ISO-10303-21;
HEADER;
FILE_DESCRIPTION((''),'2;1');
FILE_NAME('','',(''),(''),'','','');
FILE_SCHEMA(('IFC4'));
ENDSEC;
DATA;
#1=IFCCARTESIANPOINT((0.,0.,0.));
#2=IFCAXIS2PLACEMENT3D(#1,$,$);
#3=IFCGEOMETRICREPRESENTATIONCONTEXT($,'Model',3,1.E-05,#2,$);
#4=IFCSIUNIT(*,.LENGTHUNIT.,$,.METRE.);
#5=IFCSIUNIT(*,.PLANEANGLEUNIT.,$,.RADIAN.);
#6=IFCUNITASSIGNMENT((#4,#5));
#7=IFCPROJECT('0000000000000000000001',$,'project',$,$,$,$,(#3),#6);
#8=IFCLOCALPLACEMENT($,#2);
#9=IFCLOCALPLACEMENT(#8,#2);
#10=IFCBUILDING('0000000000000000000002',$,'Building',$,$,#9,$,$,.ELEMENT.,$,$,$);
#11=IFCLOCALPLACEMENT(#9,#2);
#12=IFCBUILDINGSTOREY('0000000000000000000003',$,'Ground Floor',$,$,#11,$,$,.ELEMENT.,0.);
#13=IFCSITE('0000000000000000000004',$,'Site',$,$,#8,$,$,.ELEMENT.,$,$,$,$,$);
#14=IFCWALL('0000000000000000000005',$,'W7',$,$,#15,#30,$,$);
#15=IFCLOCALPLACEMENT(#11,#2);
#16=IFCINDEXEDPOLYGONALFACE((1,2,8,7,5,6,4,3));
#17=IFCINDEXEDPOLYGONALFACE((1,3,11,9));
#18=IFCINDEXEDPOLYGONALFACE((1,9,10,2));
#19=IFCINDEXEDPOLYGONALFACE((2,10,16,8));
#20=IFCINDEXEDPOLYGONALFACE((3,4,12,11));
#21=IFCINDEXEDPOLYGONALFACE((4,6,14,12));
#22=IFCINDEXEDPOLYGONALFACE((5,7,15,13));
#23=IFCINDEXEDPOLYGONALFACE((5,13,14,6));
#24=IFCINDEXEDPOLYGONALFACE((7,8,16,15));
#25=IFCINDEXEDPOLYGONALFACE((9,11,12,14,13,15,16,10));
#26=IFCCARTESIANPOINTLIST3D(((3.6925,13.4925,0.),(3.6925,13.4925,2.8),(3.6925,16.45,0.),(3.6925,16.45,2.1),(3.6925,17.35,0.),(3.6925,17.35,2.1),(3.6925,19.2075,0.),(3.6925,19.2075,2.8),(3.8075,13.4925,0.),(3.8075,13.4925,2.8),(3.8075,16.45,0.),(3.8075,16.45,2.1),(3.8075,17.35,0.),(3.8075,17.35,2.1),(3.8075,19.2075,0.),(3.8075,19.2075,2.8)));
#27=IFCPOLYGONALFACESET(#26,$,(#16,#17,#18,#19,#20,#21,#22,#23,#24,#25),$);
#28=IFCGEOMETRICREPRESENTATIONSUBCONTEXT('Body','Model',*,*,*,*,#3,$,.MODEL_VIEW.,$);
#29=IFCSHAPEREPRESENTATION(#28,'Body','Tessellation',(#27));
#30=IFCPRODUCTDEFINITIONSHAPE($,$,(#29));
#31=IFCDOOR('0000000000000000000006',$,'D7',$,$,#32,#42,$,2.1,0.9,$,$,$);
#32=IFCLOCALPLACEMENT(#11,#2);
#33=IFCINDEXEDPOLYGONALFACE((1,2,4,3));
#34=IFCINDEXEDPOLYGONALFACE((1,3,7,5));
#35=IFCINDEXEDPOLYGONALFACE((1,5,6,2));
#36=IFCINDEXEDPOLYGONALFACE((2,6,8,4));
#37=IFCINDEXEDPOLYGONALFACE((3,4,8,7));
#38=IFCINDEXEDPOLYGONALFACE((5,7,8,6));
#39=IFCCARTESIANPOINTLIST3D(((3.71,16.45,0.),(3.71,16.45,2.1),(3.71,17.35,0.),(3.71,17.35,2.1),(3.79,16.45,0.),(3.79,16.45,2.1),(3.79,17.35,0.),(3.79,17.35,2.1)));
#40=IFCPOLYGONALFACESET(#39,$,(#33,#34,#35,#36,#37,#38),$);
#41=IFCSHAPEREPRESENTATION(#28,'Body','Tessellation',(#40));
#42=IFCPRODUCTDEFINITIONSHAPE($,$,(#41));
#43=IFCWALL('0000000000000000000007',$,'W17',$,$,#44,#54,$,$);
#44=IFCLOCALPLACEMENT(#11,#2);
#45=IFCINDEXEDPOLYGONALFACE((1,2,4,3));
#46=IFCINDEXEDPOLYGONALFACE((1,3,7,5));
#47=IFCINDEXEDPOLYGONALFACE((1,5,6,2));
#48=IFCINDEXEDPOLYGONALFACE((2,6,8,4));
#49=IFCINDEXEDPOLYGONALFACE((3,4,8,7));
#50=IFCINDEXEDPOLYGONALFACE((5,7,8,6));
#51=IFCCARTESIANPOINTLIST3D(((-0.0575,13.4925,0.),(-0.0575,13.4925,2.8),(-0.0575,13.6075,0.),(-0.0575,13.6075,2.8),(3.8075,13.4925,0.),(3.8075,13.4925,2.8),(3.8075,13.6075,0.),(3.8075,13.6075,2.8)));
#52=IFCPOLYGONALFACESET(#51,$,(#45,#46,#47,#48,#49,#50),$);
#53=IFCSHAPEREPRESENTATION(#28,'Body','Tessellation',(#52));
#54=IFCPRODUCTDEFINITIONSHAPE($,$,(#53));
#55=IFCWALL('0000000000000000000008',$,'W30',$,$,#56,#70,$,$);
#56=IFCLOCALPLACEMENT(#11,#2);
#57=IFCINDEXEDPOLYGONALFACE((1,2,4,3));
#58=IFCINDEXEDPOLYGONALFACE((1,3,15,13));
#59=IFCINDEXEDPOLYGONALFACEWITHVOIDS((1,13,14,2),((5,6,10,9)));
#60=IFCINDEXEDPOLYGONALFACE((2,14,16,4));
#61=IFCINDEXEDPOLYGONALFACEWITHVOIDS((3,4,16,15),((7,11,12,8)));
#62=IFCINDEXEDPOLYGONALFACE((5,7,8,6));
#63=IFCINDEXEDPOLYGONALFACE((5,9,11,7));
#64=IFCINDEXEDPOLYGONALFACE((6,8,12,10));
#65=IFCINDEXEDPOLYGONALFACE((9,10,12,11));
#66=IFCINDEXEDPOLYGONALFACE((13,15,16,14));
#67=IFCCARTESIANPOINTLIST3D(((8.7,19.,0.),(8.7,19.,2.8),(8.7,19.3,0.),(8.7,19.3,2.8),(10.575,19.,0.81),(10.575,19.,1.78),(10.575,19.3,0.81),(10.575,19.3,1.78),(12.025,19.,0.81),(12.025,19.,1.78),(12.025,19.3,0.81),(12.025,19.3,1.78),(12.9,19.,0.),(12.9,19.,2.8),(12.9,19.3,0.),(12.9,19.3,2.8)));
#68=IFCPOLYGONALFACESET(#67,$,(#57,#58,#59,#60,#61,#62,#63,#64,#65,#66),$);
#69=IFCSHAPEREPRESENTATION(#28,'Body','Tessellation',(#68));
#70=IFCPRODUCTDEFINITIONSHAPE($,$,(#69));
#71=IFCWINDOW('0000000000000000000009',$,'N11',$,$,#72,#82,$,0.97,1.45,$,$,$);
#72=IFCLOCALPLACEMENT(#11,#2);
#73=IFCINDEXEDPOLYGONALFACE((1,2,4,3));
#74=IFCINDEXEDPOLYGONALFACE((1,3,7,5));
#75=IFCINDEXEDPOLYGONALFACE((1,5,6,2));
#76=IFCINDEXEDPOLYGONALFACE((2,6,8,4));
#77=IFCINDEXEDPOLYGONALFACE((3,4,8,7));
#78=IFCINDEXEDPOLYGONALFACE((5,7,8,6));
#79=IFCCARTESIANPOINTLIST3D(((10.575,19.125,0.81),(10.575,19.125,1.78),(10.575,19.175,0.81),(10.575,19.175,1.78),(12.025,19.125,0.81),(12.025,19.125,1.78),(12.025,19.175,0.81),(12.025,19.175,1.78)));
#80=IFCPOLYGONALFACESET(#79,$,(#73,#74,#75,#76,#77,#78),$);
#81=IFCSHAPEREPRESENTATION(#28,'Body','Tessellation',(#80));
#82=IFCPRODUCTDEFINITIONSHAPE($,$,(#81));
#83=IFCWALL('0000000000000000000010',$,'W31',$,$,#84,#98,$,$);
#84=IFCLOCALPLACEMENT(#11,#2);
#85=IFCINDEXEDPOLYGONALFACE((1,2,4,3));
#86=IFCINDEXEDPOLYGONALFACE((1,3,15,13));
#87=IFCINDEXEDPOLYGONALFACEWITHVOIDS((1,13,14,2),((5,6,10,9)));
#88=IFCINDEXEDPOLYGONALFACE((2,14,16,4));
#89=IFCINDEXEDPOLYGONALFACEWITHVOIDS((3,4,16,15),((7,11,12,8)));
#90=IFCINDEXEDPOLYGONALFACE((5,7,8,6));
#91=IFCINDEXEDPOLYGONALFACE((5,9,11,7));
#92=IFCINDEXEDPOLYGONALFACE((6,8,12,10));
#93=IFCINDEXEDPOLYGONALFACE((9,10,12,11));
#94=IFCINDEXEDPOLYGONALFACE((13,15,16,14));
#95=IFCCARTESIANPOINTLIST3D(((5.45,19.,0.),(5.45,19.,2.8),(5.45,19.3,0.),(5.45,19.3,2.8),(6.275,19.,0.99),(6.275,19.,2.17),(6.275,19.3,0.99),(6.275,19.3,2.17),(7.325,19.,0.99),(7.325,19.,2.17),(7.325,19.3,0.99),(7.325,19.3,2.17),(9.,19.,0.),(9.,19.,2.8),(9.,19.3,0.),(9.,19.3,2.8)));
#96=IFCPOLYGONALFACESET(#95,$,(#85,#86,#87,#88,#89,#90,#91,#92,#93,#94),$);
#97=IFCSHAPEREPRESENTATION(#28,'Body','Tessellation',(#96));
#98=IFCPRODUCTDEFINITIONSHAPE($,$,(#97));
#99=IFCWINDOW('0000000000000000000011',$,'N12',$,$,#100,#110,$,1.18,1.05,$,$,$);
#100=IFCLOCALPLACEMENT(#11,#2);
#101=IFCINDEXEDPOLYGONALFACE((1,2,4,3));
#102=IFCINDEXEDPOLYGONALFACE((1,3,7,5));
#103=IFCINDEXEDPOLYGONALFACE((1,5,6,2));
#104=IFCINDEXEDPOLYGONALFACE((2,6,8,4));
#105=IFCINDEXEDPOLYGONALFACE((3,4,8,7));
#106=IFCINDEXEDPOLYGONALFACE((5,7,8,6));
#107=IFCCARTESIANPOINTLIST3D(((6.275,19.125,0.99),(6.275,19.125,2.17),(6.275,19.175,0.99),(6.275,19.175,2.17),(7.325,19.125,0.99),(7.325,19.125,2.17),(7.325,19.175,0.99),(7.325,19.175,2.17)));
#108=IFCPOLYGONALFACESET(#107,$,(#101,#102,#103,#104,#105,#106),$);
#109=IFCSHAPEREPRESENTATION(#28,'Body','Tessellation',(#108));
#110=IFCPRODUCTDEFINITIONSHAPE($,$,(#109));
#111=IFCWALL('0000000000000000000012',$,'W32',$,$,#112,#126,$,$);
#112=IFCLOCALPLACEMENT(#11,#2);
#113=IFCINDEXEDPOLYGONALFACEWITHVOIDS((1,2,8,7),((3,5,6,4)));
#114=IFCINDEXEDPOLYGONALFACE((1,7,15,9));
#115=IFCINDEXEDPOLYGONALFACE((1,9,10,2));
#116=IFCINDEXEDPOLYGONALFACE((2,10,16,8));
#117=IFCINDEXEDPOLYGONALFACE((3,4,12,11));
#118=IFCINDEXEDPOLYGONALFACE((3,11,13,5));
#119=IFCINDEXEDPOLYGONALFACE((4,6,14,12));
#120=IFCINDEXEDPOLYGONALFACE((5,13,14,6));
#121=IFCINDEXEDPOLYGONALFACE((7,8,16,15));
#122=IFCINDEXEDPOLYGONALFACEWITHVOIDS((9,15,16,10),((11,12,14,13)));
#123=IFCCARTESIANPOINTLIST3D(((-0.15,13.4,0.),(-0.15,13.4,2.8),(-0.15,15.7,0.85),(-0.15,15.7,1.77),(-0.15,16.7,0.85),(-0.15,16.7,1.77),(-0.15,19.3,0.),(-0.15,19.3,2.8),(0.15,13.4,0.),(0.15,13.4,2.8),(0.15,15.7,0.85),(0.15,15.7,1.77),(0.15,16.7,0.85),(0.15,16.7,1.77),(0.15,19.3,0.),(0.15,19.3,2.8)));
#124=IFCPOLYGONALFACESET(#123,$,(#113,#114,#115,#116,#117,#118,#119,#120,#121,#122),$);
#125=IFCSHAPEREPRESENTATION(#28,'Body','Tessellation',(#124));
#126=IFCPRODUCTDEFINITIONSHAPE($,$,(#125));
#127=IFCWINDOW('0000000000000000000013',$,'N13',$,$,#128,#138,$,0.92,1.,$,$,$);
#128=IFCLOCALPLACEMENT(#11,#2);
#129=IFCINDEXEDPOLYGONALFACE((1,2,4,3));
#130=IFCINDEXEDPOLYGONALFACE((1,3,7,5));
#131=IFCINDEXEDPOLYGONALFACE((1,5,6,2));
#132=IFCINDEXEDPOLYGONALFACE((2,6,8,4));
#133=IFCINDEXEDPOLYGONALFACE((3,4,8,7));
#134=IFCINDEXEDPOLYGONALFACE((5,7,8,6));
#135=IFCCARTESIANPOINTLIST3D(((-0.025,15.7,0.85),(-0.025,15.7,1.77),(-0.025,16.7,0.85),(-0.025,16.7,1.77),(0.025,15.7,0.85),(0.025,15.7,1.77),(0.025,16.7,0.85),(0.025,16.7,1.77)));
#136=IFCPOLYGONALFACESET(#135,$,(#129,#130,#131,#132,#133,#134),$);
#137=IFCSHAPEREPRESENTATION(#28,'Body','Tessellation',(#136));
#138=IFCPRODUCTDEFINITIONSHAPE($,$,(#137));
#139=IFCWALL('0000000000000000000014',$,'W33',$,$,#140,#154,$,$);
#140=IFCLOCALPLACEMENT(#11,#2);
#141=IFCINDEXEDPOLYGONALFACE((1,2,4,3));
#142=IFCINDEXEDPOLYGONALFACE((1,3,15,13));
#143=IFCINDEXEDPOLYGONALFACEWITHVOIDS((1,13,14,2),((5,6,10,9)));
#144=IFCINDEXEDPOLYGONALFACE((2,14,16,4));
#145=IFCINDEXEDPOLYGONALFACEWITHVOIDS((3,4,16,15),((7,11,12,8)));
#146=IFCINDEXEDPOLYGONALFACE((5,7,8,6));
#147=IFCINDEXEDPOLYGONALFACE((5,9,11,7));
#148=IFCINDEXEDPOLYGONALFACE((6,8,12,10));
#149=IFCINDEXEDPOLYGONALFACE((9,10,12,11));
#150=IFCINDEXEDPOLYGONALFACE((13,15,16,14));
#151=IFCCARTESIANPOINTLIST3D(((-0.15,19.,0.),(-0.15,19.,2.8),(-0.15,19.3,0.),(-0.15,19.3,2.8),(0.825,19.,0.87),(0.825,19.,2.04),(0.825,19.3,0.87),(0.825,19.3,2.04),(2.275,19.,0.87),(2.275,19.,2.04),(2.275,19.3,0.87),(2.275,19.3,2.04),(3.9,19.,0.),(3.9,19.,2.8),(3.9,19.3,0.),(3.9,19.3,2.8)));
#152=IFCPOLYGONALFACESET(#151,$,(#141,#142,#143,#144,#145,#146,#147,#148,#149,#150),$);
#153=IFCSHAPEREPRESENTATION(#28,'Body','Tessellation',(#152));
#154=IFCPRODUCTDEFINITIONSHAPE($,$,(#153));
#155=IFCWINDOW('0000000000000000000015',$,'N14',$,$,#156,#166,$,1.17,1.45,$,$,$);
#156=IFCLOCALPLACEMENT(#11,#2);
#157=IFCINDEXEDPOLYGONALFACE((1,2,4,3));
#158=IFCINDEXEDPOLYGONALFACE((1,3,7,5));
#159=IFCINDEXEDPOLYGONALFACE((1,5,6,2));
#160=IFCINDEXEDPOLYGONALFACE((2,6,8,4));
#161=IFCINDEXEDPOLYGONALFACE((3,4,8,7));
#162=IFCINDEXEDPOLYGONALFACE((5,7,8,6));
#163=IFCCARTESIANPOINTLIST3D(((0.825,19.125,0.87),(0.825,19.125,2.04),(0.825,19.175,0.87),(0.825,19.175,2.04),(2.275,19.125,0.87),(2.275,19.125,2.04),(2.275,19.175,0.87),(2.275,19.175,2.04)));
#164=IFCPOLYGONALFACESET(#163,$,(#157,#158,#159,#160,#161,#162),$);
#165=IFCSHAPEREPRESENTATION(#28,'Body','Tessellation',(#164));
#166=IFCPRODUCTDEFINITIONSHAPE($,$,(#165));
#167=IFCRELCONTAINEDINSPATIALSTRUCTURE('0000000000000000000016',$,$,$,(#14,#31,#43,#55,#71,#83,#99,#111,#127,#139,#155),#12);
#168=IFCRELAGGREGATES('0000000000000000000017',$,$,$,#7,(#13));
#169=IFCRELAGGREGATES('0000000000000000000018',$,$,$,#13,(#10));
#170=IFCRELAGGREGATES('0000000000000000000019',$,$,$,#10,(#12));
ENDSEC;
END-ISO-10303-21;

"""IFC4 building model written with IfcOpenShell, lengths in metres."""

from ifc_helpers import new_model, si_unit, frame, frame_2d, origin, origin_2d, place, context, subcontext, project, spatial, rectangle, extrude, element, fill, save


model = new_model("IFC4")

# Units and contexts
model_context = context("Model", 3, precision=1e-05, world=origin())
body_context = subcontext(model_context, "Body", "Model", "MODEL_VIEW")
ifc_project = project(units=[si_unit("LENGTHUNIT", "METRE"), si_unit("PLANEANGLEUNIT", "RADIAN")], contexts=[model_context])

# Site, building, storey
site_placement = place(None, origin())
site = spatial("IfcSite", under=ifc_project, at=site_placement, Name="Site", CompositionType="ELEMENT")
building_placement = place(site_placement, origin())
building = spatial("IfcBuilding", under=site, at=building_placement, Name="Building", CompositionType="ELEMENT")
storey_placement = place(building_placement, origin())
storey = spatial("IfcBuildingStorey", under=building, at=storey_placement, Name="Ground Floor", CompositionType="ELEMENT", Elevation=0.0)

# Wall, opening, door
wall_1_placement = place(storey_placement, frame((3.75, 13.55, 0.0), x_axis=(0.0, 1.0, 0.0)))
wall_1 = element("IfcWall", 1, at=wall_1_placement, inside=storey, Name="W7", context=body_context, shape_type="SweptSolid", body=[
    extrude(rectangle(XDim=5.715, YDim=0.115, at=frame_2d((2.8, 0.0))), origin(), (0.0, 0.0, 1.0), 2.8),
])
opening_1_placement = place(wall_1_placement, frame((3.35, 0.0, 0.0)))
opening_1 = element("IfcOpeningElement", 2, at=opening_1_placement, cuts=wall_1, context=body_context, shape_type="SweptSolid", body=[
    extrude(rectangle(XDim=0.9, YDim=0.215, at=origin_2d()), origin(), (0.0, 0.0, 1.0), 2.1),
])
door_1_placement = place(opening_1_placement, origin())
door_1 = element("IfcDoor", 3, at=door_1_placement, inside=storey, Name="D7", OverallHeight=2.1, OverallWidth=0.9, context=body_context, shape_type="SweptSolid", body=[
    extrude(rectangle(XDim=0.9, YDim=0.08, at=origin_2d()), origin(), (0.0, 0.0, 1.0), 2.1),
])
fill(opening_1, door_1)

# Wall
wall_2_placement = place(storey_placement, frame((0.0, 13.55, 0.0), x_axis=(1.0, 0.0, 0.0)))
element("IfcWall", 4, at=wall_2_placement, inside=storey, Name="W17", context=body_context, shape_type="SweptSolid", body=[
    extrude(rectangle(XDim=3.865, YDim=0.115, at=frame_2d((1.875, 0.0))), origin(), (0.0, 0.0, 1.0), 2.8),
])

# Walls, openings, windows
wall_3_placement = place(storey_placement, frame((8.85, 19.15, 0.0), x_axis=(1.0, 0.0, 0.0)))
wall_3 = element("IfcWall", 5, at=wall_3_placement, inside=storey, Name="W30", context=body_context, shape_type="SweptSolid", body=[
    extrude(rectangle(XDim=4.2, YDim=0.3, at=frame_2d((1.95, 0.0))), origin(), (0.0, 0.0, 1.0), 2.8),
])
opening_2_placement = place(wall_3_placement, frame((2.45, 0.0, 0.81)))
opening_2 = element("IfcOpeningElement", 6, at=opening_2_placement, cuts=wall_3, context=body_context, shape_type="SweptSolid", body=[
    extrude(rectangle(XDim=1.45, YDim=0.4, at=origin_2d()), origin(), (0.0, 0.0, 1.0), 0.97),
])
window_1_placement = place(opening_2_placement, origin())
window_1 = element("IfcWindow", 7, at=window_1_placement, inside=storey, Name="N11", OverallHeight=0.97, OverallWidth=1.45, context=body_context, shape_type="SweptSolid", body=[
    extrude(rectangle(XDim=1.45, YDim=0.05, at=origin_2d()), origin(), (0.0, 0.0, 1.0), 0.97),
])
fill(opening_2, window_1)
wall_4_placement = place(storey_placement, frame((5.6, 19.15, 0.0), x_axis=(1.0, 0.0, 0.0)))
wall_4 = element("IfcWall", 8, at=wall_4_placement, inside=storey, Name="W31", context=body_context, shape_type="SweptSolid", body=[
    extrude(rectangle(XDim=3.55, YDim=0.3, at=frame_2d((1.625, 0.0))), origin(), (0.0, 0.0, 1.0), 2.8),
])
opening_3_placement = place(wall_4_placement, frame((1.2, 0.0, 0.99)))
opening_3 = element("IfcOpeningElement", 9, at=opening_3_placement, cuts=wall_4, context=body_context, shape_type="SweptSolid", body=[
    extrude(rectangle(XDim=1.05, YDim=0.4, at=origin_2d()), origin(), (0.0, 0.0, 1.0), 1.18),
])
window_2_placement = place(opening_3_placement, origin())
window_2 = element("IfcWindow", 10, at=window_2_placement, inside=storey, Name="N12", OverallHeight=1.18, OverallWidth=1.05, context=body_context, shape_type="SweptSolid", body=[
    extrude(rectangle(XDim=1.05, YDim=0.05, at=origin_2d()), origin(), (0.0, 0.0, 1.0), 1.18),
])
fill(opening_3, window_2)
wall_5_placement = place(storey_placement, frame((0.0, 13.55, 0.0), x_axis=(0.0, 1.0, 0.0)))
wall_5 = element("IfcWall", 11, at=wall_5_placement, inside=storey, Name="W32", context=body_context, shape_type="SweptSolid", body=[
    extrude(rectangle(XDim=5.9, YDim=0.3, at=frame_2d((2.8, 0.0))), origin(), (0.0, 0.0, 1.0), 2.8),
])
opening_4_placement = place(wall_5_placement, frame((2.65, 0.0, 0.85)))
opening_4 = element("IfcOpeningElement", 12, at=opening_4_placement, cuts=wall_5, context=body_context, shape_type="SweptSolid", body=[
    extrude(rectangle(XDim=1.0, YDim=0.4, at=origin_2d()), origin(), (0.0, 0.0, 1.0), 0.92),
])
window_3_placement = place(opening_4_placement, origin())
window_3 = element("IfcWindow", 13, at=window_3_placement, inside=storey, Name="N13", OverallHeight=0.92, OverallWidth=1.0, context=body_context, shape_type="SweptSolid", body=[
    extrude(rectangle(XDim=1.0, YDim=0.05, at=origin_2d()), origin(), (0.0, 0.0, 1.0), 0.92),
])
fill(opening_4, window_3)
wall_6_placement = place(storey_placement, frame((0.0, 19.15, 0.0), x_axis=(1.0, 0.0, 0.0)))
wall_6 = element("IfcWall", 14, at=wall_6_placement, inside=storey, Name="W33", context=body_context, shape_type="SweptSolid", body=[
    extrude(rectangle(XDim=4.05, YDim=0.3, at=frame_2d((1.875, 0.0))), origin(), (0.0, 0.0, 1.0), 2.8),
])
opening_5_placement = place(wall_6_placement, frame((1.55, 0.0, 0.87)))
opening_5 = element("IfcOpeningElement", 15, at=opening_5_placement, cuts=wall_6, context=body_context, shape_type="SweptSolid", body=[
    extrude(rectangle(XDim=1.45, YDim=0.4, at=origin_2d()), origin(), (0.0, 0.0, 1.0), 1.17),
])
window_4_placement = place(opening_5_placement, origin())
window_4 = element("IfcWindow", 16, at=window_4_placement, inside=storey, Name="N14", OverallHeight=1.17, OverallWidth=1.45, context=body_context, shape_type="SweptSolid", body=[
    extrude(rectangle(XDim=1.45, YDim=0.05, at=origin_2d()), origin(), (0.0, 0.0, 1.0), 1.17),
])
fill(opening_5, window_4)

save(model, "model.ifc")
